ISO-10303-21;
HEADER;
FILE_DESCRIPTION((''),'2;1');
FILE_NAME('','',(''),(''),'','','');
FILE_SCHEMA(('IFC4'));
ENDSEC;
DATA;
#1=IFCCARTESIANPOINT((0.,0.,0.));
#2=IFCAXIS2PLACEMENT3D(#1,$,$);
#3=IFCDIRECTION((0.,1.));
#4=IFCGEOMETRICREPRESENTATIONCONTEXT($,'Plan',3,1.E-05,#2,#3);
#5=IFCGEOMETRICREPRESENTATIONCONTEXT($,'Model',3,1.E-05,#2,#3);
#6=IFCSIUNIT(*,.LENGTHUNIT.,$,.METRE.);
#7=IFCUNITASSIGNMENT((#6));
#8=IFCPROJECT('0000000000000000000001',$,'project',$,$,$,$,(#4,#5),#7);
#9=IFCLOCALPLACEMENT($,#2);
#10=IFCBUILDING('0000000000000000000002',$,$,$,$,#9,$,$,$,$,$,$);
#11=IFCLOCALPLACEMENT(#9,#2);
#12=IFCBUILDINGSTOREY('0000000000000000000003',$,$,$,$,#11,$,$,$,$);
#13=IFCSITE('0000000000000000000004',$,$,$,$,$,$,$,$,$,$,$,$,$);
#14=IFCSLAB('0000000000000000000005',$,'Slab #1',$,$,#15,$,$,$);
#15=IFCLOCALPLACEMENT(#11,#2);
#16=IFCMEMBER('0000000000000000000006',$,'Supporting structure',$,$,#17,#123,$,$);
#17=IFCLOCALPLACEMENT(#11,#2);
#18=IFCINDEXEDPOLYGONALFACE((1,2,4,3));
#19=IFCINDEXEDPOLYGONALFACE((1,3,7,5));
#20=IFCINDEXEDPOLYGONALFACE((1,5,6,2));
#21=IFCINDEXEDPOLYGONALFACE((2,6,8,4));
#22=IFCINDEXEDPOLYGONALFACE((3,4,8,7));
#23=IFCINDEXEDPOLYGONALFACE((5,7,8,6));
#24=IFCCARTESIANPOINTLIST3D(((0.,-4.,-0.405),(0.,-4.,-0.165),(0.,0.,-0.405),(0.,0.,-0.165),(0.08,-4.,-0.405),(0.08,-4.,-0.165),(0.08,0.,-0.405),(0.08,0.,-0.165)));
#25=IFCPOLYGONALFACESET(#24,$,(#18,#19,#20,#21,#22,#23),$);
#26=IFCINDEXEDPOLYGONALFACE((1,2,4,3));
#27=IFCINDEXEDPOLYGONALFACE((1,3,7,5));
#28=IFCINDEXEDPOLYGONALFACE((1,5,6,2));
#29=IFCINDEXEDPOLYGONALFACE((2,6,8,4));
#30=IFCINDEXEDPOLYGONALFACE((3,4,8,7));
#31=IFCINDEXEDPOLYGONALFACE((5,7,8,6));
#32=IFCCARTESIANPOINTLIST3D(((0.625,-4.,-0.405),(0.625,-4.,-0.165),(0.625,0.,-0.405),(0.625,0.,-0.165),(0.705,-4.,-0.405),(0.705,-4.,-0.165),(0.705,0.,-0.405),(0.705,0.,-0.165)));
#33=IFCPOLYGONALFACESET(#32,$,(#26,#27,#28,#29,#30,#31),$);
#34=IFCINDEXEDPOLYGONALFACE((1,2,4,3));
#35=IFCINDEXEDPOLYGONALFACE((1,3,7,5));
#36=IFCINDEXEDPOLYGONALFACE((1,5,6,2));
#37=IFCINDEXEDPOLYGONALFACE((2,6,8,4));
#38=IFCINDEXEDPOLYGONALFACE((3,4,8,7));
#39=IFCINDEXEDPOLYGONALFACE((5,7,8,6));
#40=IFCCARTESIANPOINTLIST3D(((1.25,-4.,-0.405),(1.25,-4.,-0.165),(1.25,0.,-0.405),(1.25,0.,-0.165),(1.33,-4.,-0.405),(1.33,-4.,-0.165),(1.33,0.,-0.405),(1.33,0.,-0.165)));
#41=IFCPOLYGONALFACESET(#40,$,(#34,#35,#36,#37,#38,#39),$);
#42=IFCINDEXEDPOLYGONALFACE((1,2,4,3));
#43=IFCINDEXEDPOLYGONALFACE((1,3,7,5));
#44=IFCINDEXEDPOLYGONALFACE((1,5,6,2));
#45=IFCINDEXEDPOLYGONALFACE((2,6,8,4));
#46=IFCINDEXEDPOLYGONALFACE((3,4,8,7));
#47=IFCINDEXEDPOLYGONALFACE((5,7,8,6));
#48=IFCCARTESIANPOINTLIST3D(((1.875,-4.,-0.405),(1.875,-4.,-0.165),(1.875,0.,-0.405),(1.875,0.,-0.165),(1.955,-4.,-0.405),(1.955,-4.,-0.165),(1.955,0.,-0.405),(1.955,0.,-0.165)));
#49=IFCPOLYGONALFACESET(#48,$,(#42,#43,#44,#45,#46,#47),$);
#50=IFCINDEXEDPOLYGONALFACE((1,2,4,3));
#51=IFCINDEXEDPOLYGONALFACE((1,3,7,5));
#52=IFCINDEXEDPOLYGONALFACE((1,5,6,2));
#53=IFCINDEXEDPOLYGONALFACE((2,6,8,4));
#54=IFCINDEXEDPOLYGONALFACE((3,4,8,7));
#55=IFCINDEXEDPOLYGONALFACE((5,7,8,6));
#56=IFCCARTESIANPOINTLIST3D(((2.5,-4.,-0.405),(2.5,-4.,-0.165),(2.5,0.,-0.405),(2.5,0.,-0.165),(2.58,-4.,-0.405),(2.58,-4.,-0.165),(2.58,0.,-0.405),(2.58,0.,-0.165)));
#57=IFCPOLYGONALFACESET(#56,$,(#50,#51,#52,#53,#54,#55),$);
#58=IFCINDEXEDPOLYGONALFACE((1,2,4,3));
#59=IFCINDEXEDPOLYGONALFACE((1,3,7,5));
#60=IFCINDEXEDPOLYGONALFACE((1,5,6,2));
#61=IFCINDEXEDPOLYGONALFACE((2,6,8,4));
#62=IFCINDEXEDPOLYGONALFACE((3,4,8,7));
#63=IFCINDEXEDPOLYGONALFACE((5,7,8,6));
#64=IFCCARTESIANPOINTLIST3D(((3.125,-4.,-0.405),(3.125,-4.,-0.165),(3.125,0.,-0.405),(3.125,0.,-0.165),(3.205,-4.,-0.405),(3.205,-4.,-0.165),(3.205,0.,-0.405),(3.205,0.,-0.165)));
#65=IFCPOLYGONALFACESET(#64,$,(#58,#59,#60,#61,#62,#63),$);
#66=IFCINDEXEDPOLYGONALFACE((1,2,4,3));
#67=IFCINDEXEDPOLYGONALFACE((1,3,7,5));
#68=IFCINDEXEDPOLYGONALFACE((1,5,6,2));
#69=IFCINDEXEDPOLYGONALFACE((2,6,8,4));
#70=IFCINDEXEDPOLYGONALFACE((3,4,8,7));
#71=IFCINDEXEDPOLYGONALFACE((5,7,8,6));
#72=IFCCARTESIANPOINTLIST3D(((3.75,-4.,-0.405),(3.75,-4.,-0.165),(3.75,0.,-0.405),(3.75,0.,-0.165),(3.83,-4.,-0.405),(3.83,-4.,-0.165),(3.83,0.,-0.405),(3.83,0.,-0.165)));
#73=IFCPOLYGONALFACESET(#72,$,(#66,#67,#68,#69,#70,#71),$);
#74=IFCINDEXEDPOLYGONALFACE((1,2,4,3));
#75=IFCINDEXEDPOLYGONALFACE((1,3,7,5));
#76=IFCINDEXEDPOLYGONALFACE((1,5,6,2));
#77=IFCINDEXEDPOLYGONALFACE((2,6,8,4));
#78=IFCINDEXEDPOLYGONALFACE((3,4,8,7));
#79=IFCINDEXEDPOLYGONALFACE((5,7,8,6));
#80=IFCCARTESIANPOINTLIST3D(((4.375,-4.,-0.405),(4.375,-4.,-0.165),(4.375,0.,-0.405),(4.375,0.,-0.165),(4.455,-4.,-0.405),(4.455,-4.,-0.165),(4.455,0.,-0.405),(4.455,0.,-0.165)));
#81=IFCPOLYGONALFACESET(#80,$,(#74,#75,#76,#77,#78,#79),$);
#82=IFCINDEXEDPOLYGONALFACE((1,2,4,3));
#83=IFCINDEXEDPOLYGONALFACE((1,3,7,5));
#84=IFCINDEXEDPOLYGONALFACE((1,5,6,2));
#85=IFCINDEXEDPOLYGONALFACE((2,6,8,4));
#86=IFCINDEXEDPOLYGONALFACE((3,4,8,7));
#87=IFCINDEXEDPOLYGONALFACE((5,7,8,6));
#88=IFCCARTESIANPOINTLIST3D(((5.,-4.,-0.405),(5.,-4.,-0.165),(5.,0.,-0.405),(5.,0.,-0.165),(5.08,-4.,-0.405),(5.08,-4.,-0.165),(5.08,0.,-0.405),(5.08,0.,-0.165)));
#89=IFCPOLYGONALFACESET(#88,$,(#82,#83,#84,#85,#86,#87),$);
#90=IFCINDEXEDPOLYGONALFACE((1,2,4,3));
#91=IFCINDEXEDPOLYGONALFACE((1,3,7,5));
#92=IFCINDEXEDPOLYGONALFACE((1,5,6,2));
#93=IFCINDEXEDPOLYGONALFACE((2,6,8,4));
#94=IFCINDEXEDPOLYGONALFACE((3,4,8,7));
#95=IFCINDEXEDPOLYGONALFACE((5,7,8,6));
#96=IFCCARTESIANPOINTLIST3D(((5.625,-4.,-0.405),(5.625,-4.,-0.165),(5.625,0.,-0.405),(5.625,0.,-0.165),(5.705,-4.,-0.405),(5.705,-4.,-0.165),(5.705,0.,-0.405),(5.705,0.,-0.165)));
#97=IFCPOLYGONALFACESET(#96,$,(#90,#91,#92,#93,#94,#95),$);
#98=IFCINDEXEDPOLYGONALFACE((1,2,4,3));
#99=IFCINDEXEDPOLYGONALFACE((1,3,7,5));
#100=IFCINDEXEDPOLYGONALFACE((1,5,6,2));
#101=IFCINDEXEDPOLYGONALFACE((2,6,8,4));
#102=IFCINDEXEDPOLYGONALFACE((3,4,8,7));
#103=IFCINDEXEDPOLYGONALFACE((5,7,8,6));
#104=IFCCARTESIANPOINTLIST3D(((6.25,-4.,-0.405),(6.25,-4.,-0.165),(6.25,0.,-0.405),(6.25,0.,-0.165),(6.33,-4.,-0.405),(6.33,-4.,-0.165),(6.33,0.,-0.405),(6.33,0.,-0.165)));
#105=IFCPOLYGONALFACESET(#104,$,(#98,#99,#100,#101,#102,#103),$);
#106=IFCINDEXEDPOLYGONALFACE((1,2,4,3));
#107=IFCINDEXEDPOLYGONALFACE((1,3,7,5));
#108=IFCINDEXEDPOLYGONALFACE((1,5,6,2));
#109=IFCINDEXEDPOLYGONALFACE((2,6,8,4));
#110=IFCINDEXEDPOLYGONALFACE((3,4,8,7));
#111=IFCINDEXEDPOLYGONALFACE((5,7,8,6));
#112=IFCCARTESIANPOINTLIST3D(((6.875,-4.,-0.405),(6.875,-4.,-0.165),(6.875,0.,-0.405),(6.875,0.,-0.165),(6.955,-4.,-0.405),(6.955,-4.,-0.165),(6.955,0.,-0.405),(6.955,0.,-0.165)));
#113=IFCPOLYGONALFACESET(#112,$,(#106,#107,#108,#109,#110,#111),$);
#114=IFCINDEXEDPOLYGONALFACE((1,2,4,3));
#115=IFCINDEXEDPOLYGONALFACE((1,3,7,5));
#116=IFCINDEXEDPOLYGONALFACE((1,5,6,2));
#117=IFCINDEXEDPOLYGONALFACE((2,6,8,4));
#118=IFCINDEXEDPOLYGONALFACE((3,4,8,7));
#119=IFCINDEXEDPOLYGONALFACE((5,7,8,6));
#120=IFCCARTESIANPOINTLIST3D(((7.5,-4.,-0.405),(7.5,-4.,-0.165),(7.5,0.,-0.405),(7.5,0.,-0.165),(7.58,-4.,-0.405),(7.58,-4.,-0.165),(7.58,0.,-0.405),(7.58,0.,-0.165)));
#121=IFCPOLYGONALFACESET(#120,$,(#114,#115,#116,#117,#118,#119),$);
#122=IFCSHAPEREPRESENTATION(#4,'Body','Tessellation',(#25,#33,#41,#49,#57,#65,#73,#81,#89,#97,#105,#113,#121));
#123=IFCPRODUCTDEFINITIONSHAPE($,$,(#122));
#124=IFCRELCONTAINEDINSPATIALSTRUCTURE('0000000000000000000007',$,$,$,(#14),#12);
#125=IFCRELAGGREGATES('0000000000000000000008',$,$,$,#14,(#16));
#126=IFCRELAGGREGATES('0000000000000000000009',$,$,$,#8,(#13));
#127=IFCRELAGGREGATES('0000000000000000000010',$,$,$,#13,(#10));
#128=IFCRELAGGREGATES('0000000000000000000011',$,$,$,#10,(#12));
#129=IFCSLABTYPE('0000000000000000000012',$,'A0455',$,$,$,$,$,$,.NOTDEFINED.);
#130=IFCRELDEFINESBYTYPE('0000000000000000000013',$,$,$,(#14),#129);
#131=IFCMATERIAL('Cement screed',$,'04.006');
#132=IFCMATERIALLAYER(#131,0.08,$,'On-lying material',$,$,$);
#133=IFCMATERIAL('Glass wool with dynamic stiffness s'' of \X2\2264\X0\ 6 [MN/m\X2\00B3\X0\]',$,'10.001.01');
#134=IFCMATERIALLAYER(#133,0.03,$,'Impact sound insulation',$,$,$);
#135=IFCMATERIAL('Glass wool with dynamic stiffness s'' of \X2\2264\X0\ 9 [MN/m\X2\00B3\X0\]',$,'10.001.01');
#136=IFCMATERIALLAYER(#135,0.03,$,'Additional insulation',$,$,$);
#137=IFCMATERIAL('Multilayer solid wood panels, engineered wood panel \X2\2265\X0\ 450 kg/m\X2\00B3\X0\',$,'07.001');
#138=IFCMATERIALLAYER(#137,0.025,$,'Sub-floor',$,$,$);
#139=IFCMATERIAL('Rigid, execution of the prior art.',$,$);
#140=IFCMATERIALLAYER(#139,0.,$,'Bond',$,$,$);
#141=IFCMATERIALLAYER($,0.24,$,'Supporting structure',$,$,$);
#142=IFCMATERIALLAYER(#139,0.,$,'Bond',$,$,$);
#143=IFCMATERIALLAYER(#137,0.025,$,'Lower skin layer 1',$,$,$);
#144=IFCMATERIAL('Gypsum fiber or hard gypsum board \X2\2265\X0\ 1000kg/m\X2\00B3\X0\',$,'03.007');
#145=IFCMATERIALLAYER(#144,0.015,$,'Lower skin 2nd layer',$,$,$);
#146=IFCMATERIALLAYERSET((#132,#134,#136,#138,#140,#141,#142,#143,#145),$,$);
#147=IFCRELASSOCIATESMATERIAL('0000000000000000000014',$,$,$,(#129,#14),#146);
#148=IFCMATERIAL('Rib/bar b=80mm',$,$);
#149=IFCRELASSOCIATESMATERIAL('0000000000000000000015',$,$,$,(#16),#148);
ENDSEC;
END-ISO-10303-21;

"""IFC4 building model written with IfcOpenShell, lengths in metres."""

from ifc_helpers import new_model, si_unit, direction, frame, frame_2d, origin, place, context, project, spatial, rectangle, extrude, material, layer, layer_set, type_object, element, aggregate, save


model = new_model("IFC4")

# Units and contexts
plan_context = context("Plan", 3, precision=1e-05, world=origin(), true_north=direction((0.0, 1.0)))
model_context = context("Model", 3, precision=1e-05, world=origin(), true_north=direction((0.0, 1.0)))
ifc_project = project(units=[si_unit("LENGTHUNIT", "METRE")], contexts=[plan_context, model_context])

# Site, building, storey
site = spatial("IfcSite", under=ifc_project)
building_placement = place(None, origin())
building = spatial("IfcBuilding", under=site, at=building_placement)
storey_placement = place(building_placement, origin())
storey = spatial("IfcBuildingStorey", under=building, at=storey_placement)

# Slab, member
ifc_material_1 = material(Name="Cement screed", Category="04.006")
ifc_layer_1 = layer(ifc_material_1, 0.08, Name="On-lying material")
ifc_material_2 = material(Name="Glass wool with dynamic stiffness s' of ≤ 6 [MN/m³]", Category="10.001.01")
ifc_layer_2 = layer(ifc_material_2, 0.03, Name="Impact sound insulation")
ifc_material_3 = material(Name="Glass wool with dynamic stiffness s' of ≤ 9 [MN/m³]", Category="10.001.01")
ifc_layer_3 = layer(ifc_material_3, 0.03, Name="Additional insulation")
ifc_material_4 = material(Name="Multilayer solid wood panels, engineered wood panel ≥ 450 kg/m³", Category="07.001")
ifc_layer_4 = layer(ifc_material_4, 0.025, Name="Sub-floor")
ifc_material_5 = material(Name="Rigid, execution of the prior art.")
ifc_layer_5 = layer(ifc_material_5, 0.0, Name="Bond")
ifc_layer_6 = layer(None, 0.24, Name="Supporting structure")
ifc_layer_7 = layer(ifc_material_5, 0.0, Name="Bond")
ifc_layer_8 = layer(ifc_material_4, 0.025, Name="Lower skin layer 1")
ifc_material_6 = material(Name="Gypsum fiber or hard gypsum board ≥ 1000kg/m³", Category="03.007")
ifc_layer_9 = layer(ifc_material_6, 0.015, Name="Lower skin 2nd layer")
ifc_layer_set = layer_set([ifc_layer_1, ifc_layer_2, ifc_layer_3, ifc_layer_4, ifc_layer_5, ifc_layer_6, ifc_layer_7, ifc_layer_8, ifc_layer_9])
slab_type = type_object("IfcSlabType", Name="A0455", PredefinedType="NOTDEFINED", material=ifc_layer_set)
slab_placement = place(None, frame((0.0, 0.0, 0.0), z_axis=(0.0, 0.0, -1.0), x_axis=(1.0, 0.0, 0.0)))
slab = element("IfcSlab", 1, at=slab_placement, inside=storey, type_object=slab_type, material=ifc_layer_set, Name="Slab #1")
ifc_material_7 = material(Name="Rib/bar b=80mm")
member_1_placement = place(slab_placement, origin())
member_1 = element("IfcMember", 2, at=member_1_placement, material=ifc_material_7, Name="Supporting structure", context=plan_context, shape_type="SweptSolid", body=[
    extrude(rectangle(XDim=0.08, YDim=0.24, at=frame_2d((0.04, 0.12), x_axis=(1.0, 0.0))), frame((0.0, 4.0, 0.165), z_axis=(0.0, -1.0, 0.0), x_axis=(1.0, 0.0, 0.0)), (0.0, 0.0, 1.0), 4.0),
    extrude(rectangle(XDim=0.08, YDim=0.24, at=frame_2d((0.04, 0.12), x_axis=(1.0, 0.0))), frame((0.625, 4.0, 0.165), z_axis=(0.0, -1.0, 0.0), x_axis=(1.0, 0.0, 0.0)), (0.0, 0.0, 1.0), 4.0),
    extrude(rectangle(XDim=0.08, YDim=0.24, at=frame_2d((0.04, 0.12), x_axis=(1.0, 0.0))), frame((1.25, 4.0, 0.165), z_axis=(0.0, -1.0, 0.0), x_axis=(1.0, 0.0, 0.0)), (0.0, 0.0, 1.0), 4.0),
    extrude(rectangle(XDim=0.08, YDim=0.24, at=frame_2d((0.04, 0.12), x_axis=(1.0, 0.0))), frame((1.875, 4.0, 0.165), z_axis=(0.0, -1.0, 0.0), x_axis=(1.0, 0.0, 0.0)), (0.0, 0.0, 1.0), 4.0),
    extrude(rectangle(XDim=0.08, YDim=0.24, at=frame_2d((0.04, 0.12), x_axis=(1.0, 0.0))), frame((2.5, 4.0, 0.165), z_axis=(0.0, -1.0, 0.0), x_axis=(1.0, 0.0, 0.0)), (0.0, 0.0, 1.0), 4.0),
    extrude(rectangle(XDim=0.08, YDim=0.24, at=frame_2d((0.04, 0.12), x_axis=(1.0, 0.0))), frame((3.125, 4.0, 0.165), z_axis=(0.0, -1.0, 0.0), x_axis=(1.0, 0.0, 0.0)), (0.0, 0.0, 1.0), 4.0),
    extrude(rectangle(XDim=0.08, YDim=0.24, at=frame_2d((0.04, 0.12), x_axis=(1.0, 0.0))), frame((3.75, 4.0, 0.165), z_axis=(0.0, -1.0, 0.0), x_axis=(1.0, 0.0, 0.0)), (0.0, 0.0, 1.0), 4.0),
    extrude(rectangle(XDim=0.08, YDim=0.24, at=frame_2d((0.04, 0.12), x_axis=(1.0, 0.0))), frame((4.375, 4.0, 0.165), z_axis=(0.0, -1.0, 0.0), x_axis=(1.0, 0.0, 0.0)), (0.0, 0.0, 1.0), 4.0),
    extrude(rectangle(XDim=0.08, YDim=0.24, at=frame_2d((0.04, 0.12), x_axis=(1.0, 0.0))), frame((5.0, 4.0, 0.165), z_axis=(0.0, -1.0, 0.0), x_axis=(1.0, 0.0, 0.0)), (0.0, 0.0, 1.0), 4.0),
    extrude(rectangle(XDim=0.08, YDim=0.24, at=frame_2d((0.04, 0.12), x_axis=(1.0, 0.0))), frame((5.625, 4.0, 0.165), z_axis=(0.0, -1.0, 0.0), x_axis=(1.0, 0.0, 0.0)), (0.0, 0.0, 1.0), 4.0),
    extrude(rectangle(XDim=0.08, YDim=0.24, at=frame_2d((0.04, 0.12), x_axis=(1.0, 0.0))), frame((6.25, 4.0, 0.165), z_axis=(0.0, -1.0, 0.0), x_axis=(1.0, 0.0, 0.0)), (0.0, 0.0, 1.0), 4.0),
    extrude(rectangle(XDim=0.08, YDim=0.24, at=frame_2d((0.04, 0.12), x_axis=(1.0, 0.0))), frame((6.875, 4.0, 0.165), z_axis=(0.0, -1.0, 0.0), x_axis=(1.0, 0.0, 0.0)), (0.0, 0.0, 1.0), 4.0),
    extrude(rectangle(XDim=0.08, YDim=0.24, at=frame_2d((0.04, 0.12), x_axis=(1.0, 0.0))), frame((7.5, 4.0, 0.165), z_axis=(0.0, -1.0, 0.0), x_axis=(1.0, 0.0, 0.0)), (0.0, 0.0, 1.0), 4.0),
])
aggregate(slab, [member_1])

save(model, "model.ifc")
